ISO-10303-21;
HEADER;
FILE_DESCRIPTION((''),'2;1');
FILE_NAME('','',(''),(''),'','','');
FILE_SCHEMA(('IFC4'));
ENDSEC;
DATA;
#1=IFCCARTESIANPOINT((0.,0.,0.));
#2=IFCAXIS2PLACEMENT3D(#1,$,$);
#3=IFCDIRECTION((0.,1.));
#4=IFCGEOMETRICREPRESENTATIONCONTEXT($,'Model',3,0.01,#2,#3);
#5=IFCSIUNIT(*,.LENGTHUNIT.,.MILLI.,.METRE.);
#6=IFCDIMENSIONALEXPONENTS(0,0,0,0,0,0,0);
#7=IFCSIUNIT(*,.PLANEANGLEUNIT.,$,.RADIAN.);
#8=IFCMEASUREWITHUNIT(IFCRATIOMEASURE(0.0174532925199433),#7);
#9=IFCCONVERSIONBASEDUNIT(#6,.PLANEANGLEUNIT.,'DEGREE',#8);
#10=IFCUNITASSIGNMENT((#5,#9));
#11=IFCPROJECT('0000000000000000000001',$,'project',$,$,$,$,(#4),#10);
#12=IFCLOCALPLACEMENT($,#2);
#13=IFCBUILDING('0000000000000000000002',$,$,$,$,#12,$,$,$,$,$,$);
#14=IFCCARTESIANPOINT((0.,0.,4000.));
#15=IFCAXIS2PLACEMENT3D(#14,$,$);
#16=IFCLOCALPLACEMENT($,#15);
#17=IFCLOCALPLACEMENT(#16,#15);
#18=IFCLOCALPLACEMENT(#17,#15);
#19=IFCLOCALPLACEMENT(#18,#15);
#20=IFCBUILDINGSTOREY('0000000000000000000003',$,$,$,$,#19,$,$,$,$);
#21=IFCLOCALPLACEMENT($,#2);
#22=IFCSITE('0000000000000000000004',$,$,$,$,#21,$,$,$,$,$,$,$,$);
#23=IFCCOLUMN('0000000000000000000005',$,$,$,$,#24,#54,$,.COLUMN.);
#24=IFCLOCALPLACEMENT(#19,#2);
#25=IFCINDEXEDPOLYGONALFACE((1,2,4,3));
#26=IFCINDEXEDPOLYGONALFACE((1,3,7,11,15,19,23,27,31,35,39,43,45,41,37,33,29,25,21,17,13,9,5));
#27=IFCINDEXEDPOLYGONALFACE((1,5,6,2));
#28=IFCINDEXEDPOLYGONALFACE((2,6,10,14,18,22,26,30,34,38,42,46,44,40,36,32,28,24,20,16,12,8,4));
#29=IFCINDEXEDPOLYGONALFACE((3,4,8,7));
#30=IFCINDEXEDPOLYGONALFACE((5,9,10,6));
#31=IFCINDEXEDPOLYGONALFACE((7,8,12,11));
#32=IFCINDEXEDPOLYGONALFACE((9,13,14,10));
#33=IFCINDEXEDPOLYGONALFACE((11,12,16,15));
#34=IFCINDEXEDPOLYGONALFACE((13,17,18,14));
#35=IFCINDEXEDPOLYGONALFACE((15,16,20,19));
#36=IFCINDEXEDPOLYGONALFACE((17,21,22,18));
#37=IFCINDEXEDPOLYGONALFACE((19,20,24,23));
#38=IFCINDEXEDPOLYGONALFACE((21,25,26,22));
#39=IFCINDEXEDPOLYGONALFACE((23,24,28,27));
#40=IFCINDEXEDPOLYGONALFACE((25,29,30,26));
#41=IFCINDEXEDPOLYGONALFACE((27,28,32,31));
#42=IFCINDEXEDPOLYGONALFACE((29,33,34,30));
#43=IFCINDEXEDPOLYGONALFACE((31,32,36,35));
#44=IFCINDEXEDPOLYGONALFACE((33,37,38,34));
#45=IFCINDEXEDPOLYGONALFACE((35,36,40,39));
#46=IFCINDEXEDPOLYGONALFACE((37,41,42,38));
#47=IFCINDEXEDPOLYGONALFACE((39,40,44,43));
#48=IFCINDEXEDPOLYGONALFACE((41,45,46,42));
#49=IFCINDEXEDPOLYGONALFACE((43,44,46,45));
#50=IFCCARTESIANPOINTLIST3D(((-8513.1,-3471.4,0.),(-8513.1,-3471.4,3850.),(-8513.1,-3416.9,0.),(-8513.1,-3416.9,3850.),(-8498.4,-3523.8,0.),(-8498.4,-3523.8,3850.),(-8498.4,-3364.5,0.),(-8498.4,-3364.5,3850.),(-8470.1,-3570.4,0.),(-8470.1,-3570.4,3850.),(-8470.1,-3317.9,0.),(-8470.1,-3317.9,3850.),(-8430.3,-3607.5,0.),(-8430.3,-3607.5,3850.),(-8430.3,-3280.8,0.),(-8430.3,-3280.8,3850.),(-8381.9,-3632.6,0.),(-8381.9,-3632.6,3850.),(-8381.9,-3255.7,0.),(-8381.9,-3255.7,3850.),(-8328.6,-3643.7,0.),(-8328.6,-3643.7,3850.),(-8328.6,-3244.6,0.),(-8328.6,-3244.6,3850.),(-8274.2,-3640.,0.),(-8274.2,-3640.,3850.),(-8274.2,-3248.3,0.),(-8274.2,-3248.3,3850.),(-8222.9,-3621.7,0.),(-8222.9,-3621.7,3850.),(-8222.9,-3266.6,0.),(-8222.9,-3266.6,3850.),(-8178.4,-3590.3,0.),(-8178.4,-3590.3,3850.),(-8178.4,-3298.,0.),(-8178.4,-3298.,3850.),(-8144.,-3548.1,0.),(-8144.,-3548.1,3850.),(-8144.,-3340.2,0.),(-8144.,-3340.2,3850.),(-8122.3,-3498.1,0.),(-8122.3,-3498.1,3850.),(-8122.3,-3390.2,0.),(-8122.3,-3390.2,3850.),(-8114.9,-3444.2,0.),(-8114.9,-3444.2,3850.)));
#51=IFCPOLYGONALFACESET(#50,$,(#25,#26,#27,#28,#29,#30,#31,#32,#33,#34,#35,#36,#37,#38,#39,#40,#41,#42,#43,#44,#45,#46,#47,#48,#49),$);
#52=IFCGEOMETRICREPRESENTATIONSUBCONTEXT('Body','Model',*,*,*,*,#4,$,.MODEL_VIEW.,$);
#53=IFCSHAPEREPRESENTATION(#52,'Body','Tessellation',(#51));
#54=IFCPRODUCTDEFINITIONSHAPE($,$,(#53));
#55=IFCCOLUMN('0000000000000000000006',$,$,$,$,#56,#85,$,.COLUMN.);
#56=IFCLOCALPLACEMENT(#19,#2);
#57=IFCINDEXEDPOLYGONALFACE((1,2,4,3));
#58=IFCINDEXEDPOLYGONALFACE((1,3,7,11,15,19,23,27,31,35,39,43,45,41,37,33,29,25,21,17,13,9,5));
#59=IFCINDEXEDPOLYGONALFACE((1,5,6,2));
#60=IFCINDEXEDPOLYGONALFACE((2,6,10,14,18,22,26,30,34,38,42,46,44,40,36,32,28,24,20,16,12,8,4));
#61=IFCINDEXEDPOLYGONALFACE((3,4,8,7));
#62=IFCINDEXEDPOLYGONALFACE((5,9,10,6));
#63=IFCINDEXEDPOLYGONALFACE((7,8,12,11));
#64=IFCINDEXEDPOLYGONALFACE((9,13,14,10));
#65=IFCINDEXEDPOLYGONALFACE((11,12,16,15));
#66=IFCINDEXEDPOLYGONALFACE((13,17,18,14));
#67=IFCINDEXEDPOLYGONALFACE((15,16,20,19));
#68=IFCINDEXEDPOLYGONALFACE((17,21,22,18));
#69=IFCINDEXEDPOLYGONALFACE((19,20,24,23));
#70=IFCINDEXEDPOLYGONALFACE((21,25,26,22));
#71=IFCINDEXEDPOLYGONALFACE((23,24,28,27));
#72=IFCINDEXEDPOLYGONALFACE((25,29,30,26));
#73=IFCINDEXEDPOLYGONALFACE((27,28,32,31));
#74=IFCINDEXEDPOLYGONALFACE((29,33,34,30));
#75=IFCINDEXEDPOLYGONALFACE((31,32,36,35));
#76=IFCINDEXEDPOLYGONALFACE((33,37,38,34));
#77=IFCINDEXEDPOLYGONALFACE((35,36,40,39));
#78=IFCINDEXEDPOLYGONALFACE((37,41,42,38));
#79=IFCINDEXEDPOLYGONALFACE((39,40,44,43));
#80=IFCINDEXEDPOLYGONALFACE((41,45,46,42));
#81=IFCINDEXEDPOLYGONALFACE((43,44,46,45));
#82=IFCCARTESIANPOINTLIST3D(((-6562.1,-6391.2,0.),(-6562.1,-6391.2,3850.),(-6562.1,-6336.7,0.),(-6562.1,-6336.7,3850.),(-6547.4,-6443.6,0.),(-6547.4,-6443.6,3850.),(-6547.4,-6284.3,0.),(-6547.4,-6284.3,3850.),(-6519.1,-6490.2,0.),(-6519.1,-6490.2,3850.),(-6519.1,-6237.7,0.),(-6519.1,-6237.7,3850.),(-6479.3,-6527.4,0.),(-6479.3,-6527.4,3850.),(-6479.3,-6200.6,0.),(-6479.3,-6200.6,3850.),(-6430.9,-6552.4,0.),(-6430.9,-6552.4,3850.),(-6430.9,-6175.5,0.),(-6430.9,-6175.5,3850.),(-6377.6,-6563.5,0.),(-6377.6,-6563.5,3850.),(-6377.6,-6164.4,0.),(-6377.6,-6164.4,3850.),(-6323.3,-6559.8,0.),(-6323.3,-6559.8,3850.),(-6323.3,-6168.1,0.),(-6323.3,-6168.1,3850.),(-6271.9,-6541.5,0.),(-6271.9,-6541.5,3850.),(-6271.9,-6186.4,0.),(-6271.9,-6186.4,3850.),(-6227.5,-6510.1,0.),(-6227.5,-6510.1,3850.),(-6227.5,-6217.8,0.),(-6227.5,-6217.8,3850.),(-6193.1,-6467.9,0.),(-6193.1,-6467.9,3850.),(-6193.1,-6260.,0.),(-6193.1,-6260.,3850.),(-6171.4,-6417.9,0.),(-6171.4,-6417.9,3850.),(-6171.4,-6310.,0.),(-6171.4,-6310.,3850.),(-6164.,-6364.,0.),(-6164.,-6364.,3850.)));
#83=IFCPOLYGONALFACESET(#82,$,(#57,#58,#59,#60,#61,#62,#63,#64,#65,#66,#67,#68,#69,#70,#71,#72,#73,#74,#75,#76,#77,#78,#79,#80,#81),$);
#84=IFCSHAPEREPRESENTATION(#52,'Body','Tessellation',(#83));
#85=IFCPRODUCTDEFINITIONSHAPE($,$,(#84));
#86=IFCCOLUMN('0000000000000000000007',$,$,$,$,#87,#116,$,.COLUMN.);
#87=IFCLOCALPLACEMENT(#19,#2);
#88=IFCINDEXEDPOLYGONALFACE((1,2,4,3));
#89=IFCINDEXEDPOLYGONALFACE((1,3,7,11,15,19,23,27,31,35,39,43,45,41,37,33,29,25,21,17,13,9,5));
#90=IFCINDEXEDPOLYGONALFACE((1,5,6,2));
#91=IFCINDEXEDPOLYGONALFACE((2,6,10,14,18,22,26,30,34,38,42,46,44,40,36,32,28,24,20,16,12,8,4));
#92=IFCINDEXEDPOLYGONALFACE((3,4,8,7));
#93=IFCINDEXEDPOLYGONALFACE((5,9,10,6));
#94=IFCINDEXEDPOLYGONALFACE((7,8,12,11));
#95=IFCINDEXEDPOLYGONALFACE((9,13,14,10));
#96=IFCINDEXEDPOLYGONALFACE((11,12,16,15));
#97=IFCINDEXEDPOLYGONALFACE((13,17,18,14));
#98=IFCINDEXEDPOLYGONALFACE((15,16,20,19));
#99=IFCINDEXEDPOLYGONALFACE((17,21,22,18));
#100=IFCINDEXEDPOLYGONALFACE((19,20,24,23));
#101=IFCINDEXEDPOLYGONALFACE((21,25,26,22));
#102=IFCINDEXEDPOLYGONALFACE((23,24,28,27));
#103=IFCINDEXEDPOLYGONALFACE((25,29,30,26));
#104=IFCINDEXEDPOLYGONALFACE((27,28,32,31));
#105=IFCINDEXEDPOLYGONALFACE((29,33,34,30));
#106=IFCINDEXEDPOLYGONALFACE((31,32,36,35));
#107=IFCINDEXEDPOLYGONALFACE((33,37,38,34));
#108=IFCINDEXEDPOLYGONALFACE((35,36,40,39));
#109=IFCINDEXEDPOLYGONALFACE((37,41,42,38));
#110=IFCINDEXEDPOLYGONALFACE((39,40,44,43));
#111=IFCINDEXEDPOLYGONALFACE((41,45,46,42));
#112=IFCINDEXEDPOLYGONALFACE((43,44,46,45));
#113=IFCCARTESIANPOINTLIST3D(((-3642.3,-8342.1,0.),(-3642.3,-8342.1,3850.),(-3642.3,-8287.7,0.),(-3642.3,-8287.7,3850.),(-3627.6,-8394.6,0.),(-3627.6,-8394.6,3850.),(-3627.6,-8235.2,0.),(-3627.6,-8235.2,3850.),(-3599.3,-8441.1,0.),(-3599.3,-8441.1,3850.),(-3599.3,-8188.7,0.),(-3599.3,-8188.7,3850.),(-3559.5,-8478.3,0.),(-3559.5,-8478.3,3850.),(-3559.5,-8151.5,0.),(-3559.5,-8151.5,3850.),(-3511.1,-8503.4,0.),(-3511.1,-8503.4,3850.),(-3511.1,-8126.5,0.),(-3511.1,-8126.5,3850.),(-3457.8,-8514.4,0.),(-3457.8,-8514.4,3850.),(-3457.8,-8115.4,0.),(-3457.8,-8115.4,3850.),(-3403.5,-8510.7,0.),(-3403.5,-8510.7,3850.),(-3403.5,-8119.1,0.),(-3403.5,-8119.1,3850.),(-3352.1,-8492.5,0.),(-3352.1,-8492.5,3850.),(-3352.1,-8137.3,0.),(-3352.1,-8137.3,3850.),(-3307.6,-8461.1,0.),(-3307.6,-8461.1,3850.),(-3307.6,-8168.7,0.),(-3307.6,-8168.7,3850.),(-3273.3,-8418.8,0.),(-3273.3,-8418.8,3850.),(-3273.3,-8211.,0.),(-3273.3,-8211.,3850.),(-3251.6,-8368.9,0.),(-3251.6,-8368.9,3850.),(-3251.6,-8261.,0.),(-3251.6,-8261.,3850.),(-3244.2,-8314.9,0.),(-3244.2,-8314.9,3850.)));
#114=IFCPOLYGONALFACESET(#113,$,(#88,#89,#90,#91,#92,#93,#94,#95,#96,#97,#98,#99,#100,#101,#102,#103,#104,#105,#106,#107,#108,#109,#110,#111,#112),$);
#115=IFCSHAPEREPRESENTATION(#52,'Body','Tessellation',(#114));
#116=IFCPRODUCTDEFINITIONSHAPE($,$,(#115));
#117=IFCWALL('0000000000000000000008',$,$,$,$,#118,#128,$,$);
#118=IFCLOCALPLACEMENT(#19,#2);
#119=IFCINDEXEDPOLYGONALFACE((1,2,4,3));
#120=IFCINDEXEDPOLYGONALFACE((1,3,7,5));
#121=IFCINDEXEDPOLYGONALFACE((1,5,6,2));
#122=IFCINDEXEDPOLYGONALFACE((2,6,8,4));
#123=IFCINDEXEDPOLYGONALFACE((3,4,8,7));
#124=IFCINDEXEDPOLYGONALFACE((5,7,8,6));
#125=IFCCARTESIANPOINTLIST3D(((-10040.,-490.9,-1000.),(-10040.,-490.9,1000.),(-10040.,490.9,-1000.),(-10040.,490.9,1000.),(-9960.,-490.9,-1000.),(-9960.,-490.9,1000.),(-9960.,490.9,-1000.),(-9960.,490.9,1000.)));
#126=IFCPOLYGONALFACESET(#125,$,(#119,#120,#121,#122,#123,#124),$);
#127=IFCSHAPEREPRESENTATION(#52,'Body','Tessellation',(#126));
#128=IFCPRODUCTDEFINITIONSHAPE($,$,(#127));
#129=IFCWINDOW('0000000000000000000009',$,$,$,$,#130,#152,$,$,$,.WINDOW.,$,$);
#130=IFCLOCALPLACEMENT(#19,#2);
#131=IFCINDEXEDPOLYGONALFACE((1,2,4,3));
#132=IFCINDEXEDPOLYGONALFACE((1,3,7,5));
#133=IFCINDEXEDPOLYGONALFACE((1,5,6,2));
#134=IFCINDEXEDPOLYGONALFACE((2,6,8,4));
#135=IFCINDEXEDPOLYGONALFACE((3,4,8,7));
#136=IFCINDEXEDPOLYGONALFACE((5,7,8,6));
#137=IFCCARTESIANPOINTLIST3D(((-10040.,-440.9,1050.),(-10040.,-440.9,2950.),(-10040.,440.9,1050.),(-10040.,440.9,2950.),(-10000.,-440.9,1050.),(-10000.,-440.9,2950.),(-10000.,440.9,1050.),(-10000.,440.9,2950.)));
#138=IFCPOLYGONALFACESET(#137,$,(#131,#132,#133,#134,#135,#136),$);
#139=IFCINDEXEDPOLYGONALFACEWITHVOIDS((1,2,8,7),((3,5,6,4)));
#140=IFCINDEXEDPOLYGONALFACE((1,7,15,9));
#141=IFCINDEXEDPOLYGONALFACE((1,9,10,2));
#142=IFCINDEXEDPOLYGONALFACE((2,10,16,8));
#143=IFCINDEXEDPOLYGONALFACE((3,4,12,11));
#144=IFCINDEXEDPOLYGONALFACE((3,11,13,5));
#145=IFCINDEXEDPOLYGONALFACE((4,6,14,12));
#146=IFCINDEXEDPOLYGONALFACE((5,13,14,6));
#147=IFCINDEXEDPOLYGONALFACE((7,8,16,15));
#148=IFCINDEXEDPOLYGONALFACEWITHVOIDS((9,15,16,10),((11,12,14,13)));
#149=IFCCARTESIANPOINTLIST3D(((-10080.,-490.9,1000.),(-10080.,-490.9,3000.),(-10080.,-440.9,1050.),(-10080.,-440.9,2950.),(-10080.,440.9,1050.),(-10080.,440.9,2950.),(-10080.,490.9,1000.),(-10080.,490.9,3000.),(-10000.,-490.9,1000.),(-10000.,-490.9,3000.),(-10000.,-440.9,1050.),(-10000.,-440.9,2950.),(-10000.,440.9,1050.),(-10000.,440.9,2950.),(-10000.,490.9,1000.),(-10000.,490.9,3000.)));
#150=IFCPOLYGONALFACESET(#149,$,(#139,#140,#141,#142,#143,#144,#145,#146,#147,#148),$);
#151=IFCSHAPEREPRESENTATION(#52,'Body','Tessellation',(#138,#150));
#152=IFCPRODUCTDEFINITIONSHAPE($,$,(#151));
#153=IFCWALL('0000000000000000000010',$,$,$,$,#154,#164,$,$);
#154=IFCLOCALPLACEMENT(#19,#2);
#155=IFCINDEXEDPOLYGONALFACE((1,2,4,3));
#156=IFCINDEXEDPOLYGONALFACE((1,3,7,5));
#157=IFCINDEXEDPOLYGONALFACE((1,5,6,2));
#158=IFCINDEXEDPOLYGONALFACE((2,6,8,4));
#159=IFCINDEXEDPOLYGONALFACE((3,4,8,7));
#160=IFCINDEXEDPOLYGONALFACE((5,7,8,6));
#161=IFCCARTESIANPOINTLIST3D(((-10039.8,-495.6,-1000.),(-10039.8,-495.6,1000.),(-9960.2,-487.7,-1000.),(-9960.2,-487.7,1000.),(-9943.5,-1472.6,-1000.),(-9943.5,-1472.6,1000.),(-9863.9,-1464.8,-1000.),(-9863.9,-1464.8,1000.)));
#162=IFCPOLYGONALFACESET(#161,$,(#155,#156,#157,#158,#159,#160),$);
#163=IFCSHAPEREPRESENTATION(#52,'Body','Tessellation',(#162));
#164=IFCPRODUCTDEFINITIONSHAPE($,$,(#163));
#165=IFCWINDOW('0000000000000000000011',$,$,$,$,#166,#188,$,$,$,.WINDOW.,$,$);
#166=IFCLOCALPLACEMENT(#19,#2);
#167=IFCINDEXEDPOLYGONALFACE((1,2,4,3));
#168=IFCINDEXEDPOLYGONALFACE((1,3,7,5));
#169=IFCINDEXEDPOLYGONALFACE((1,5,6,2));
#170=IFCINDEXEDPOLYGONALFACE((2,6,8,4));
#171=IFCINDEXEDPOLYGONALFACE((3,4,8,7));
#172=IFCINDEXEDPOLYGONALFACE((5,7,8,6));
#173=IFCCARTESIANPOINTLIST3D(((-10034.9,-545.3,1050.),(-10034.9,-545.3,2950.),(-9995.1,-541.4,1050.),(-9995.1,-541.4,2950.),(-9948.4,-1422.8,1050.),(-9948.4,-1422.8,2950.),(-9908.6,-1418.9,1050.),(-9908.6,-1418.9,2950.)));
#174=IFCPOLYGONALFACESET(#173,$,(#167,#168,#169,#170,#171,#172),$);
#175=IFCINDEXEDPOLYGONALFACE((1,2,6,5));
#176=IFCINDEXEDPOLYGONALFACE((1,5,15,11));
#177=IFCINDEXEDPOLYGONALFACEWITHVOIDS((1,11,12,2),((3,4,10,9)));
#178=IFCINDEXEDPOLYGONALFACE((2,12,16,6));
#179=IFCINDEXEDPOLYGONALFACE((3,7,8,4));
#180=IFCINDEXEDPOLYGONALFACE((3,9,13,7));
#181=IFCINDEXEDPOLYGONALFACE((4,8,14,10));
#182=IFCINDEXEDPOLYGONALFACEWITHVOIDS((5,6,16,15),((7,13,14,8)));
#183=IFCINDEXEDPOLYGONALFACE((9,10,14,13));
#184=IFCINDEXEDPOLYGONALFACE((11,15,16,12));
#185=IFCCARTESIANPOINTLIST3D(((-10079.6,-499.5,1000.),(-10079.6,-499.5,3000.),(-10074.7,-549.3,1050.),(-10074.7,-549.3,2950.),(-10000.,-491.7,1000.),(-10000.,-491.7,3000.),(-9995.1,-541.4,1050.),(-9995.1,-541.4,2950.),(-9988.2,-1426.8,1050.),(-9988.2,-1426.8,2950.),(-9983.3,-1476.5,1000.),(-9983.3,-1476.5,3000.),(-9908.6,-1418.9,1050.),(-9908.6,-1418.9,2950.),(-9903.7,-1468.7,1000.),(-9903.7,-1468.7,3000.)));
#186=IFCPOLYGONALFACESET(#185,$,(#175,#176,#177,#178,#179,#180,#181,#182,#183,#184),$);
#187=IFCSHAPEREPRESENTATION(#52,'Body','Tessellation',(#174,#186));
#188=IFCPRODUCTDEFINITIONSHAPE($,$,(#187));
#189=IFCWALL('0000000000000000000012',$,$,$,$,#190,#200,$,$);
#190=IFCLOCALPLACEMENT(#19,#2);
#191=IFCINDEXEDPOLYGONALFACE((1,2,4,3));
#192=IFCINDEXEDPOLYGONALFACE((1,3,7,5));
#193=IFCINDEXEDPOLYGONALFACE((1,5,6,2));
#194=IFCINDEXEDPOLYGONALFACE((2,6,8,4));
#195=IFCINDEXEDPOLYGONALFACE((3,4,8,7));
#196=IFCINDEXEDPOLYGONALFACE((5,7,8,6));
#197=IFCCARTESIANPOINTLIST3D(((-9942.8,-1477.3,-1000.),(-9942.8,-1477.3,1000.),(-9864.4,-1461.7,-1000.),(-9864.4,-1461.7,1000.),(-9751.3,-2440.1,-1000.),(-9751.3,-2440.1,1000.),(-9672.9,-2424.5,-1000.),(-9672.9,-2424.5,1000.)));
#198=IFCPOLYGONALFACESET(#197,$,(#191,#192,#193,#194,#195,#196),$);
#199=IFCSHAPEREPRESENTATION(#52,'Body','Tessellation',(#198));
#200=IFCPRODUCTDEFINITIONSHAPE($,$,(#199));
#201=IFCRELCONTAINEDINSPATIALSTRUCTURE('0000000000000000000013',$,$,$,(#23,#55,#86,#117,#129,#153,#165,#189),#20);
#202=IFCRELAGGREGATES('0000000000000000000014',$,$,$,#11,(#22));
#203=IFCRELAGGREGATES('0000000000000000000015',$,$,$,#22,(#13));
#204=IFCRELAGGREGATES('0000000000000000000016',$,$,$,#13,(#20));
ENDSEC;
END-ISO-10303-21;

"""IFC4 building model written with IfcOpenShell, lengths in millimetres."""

from ifc_helpers import new_model, entity, si_unit, converted_unit, direction, frame, origin, origin_2d, place, context, subcontext, project, spatial, rectangle, circle, extrude, element, save


model = new_model("IFC4")

# Units and contexts
model_context = context("Model", 3, precision=0.01, world=origin(), true_north=direction((0.0, 1.0)))
body_context = subcontext(model_context, "Body", "Model", "MODEL_VIEW")
ifc_project = project(units=[si_unit("LENGTHUNIT", "METRE", prefix="MILLI"), converted_unit("PLANEANGLEUNIT", "DEGREE", entity("IfcRatioMeasure", 0.0174532925199433), si_unit("PLANEANGLEUNIT", "RADIAN"), dimensions=[0, 0, 0, 0, 0, 0, 0])], contexts=[model_context])

# Site, building, storey
site_placement = place(None, origin())
site = spatial("IfcSite", under=ifc_project, at=site_placement)
building_placement = place(None, origin())
building = spatial("IfcBuilding", under=site, at=building_placement)
placement_1 = place(None, frame((0.0, 0.0, 4000.0)))
placement_2 = place(placement_1, frame((0.0, 0.0, 4000.0)))
placement_3 = place(placement_2, frame((0.0, 0.0, 4000.0)))
storey_placement = place(placement_3, frame((0.0, 0.0, 4000.0)))
storey = spatial("IfcBuildingStorey", under=building, at=storey_placement)

# Columns
for number, where in (
    (1, (-8314.9, -3444.2, 0.0)),
    (2, (-6364.0, -6364.0, 0.0)),
    (3, (-3444.2, -8314.9, 0.0)),
):
    element("IfcColumn", number, at=place(storey_placement, frame(where)), inside=storey, PredefinedType="COLUMN", context=body_context, shape_type="SweptSolid", body=[
        extrude(circle(Radius=200.0, at=origin_2d()), origin(), (0.0, 0.0, 1.0), 3850.0),
    ])

# Wall
wall_1_placement = place(storey_placement, frame((-10000.0, 0.0, -1000.0), z_axis=(0.0, 0.0, 1.0), x_axis=(0.000874, -10000.0, 0.0)))
element("IfcWall", 4, at=wall_1_placement, inside=storey, context=body_context, shape_type="SweptSolid", body=[
    extrude(rectangle(XDim=981.7, YDim=80.0, at=origin_2d()), origin(), (0.0, 0.0, 1.0), 2000.0),
])

# Window
cartesian_point_1 = entity("IfcCartesianPoint", [-440.9, -950.0])
shared_polyline = entity("IfcPolyline", [cartesian_point_1, entity("IfcCartesianPoint", [-440.9, 950.0]), entity("IfcCartesianPoint", [-440.9, 950.0]), entity("IfcCartesianPoint", [440.9, 950.0]), entity("IfcCartesianPoint", [440.9, 950.0]), entity("IfcCartesianPoint", [440.9, -950.0]), entity("IfcCartesianPoint", [440.9, -950.0]), entity("IfcCartesianPoint", [-440.9, -950.0]), cartesian_point_1])
window_1_placement = place(storey_placement, frame((-10000.0, 0.0, 2000.0), z_axis=(0.0, 0.0, 1.0), x_axis=(0.000874, -10000.0, 0.0)))
cartesian_point_2 = entity("IfcCartesianPoint", [-490.9, -1000.0])
element("IfcWindow", 5, at=window_1_placement, inside=storey, PredefinedType="WINDOW", context=body_context, shape_type="SweptSolid", body=[
    entity("IfcExtrudedAreaSolid", entity("IfcArbitraryClosedProfileDef", "AREA", None, shared_polyline), entity("IfcAxis2Placement3D", entity("IfcCartesianPoint", [0.0, 0.0, 0.0]), entity("IfcDirection", [0.0, -1.0, 0.0]), entity("IfcDirection", [1.0, 0.0, 0.0])), entity("IfcDirection", [0.0, 0.0, 1.0]), 40.0),
    entity("IfcExtrudedAreaSolid", entity("IfcArbitraryProfileDefWithVoids", "AREA", None, entity("IfcPolyline", [cartesian_point_2, entity("IfcCartesianPoint", [-490.9, 1000.0]), entity("IfcCartesianPoint", [-490.9, 1000.0]), entity("IfcCartesianPoint", [490.9, 1000.0]), entity("IfcCartesianPoint", [490.9, 1000.0]), entity("IfcCartesianPoint", [490.9, -1000.0]), entity("IfcCartesianPoint", [490.9, -1000.0]), entity("IfcCartesianPoint", [-490.9, -1000.0]), cartesian_point_2]), [shared_polyline]), entity("IfcAxis2Placement3D", entity("IfcCartesianPoint", [0.0, 0.0, 0.0]), entity("IfcDirection", [0.0, -1.0, 0.0]), entity("IfcDirection", [1.0, 0.0, 0.0])), entity("IfcDirection", [0.0, 0.0, 1.0]), 80.0),
])

# Wall
wall_2_placement = place(storey_placement, frame((-9951.8, -980.2, -1000.0), z_axis=(0.0, 0.0, 1.0), x_axis=(980.170299, -9951.847376, 0.0)))
element("IfcWall", 6, at=wall_2_placement, inside=storey, context=body_context, shape_type="SweptSolid", body=[
    extrude(rectangle(XDim=981.7, YDim=80.0, at=origin_2d()), origin(), (0.0, 0.0, 1.0), 2000.0),
])

# Window
window_2_placement = place(storey_placement, frame((-9951.8, -980.2, 2000.0), z_axis=(0.0, 0.0, 1.0), x_axis=(980.170299, -9951.847376, 0.0)))
cartesian_point_3 = entity("IfcCartesianPoint", [-490.9, -1000.0])
element("IfcWindow", 7, at=window_2_placement, inside=storey, PredefinedType="WINDOW", context=body_context, shape_type="SweptSolid", body=[
    entity("IfcExtrudedAreaSolid", entity("IfcArbitraryClosedProfileDef", "AREA", None, shared_polyline), entity("IfcAxis2Placement3D", entity("IfcCartesianPoint", [0.0, 0.0, 0.0]), entity("IfcDirection", [0.0, -1.0, 0.0]), entity("IfcDirection", [1.0, 0.0, 0.0])), entity("IfcDirection", [0.0, 0.0, 1.0]), 40.0),
    entity("IfcExtrudedAreaSolid", entity("IfcArbitraryProfileDefWithVoids", "AREA", None, entity("IfcPolyline", [cartesian_point_3, entity("IfcCartesianPoint", [-490.9, 1000.0]), entity("IfcCartesianPoint", [-490.9, 1000.0]), entity("IfcCartesianPoint", [490.9, 1000.0]), entity("IfcCartesianPoint", [490.9, 1000.0]), entity("IfcCartesianPoint", [490.9, -1000.0]), entity("IfcCartesianPoint", [490.9, -1000.0]), entity("IfcCartesianPoint", [-490.9, -1000.0]), cartesian_point_3]), [shared_polyline]), entity("IfcAxis2Placement3D", entity("IfcCartesianPoint", [0.0, 0.0, 0.0]), entity("IfcDirection", [0.0, -1.0, 0.0]), entity("IfcDirection", [1.0, 0.0, 0.0])), entity("IfcDirection", [0.0, 0.0, 1.0]), 80.0),
])

# Wall
wall_3_placement = place(storey_placement, frame((-9807.9, -1950.9, -1000.0), z_axis=(0.0, 0.0, 1.0), x_axis=(1950.902524, -9807.852943, 0.0)))
element("IfcWall", 8, at=wall_3_placement, inside=storey, context=body_context, shape_type="SweptSolid", body=[
    extrude(rectangle(XDim=981.7, YDim=80.0, at=origin_2d()), origin(), (0.0, 0.0, 1.0), 2000.0),
])

save(model, "model.ifc")
